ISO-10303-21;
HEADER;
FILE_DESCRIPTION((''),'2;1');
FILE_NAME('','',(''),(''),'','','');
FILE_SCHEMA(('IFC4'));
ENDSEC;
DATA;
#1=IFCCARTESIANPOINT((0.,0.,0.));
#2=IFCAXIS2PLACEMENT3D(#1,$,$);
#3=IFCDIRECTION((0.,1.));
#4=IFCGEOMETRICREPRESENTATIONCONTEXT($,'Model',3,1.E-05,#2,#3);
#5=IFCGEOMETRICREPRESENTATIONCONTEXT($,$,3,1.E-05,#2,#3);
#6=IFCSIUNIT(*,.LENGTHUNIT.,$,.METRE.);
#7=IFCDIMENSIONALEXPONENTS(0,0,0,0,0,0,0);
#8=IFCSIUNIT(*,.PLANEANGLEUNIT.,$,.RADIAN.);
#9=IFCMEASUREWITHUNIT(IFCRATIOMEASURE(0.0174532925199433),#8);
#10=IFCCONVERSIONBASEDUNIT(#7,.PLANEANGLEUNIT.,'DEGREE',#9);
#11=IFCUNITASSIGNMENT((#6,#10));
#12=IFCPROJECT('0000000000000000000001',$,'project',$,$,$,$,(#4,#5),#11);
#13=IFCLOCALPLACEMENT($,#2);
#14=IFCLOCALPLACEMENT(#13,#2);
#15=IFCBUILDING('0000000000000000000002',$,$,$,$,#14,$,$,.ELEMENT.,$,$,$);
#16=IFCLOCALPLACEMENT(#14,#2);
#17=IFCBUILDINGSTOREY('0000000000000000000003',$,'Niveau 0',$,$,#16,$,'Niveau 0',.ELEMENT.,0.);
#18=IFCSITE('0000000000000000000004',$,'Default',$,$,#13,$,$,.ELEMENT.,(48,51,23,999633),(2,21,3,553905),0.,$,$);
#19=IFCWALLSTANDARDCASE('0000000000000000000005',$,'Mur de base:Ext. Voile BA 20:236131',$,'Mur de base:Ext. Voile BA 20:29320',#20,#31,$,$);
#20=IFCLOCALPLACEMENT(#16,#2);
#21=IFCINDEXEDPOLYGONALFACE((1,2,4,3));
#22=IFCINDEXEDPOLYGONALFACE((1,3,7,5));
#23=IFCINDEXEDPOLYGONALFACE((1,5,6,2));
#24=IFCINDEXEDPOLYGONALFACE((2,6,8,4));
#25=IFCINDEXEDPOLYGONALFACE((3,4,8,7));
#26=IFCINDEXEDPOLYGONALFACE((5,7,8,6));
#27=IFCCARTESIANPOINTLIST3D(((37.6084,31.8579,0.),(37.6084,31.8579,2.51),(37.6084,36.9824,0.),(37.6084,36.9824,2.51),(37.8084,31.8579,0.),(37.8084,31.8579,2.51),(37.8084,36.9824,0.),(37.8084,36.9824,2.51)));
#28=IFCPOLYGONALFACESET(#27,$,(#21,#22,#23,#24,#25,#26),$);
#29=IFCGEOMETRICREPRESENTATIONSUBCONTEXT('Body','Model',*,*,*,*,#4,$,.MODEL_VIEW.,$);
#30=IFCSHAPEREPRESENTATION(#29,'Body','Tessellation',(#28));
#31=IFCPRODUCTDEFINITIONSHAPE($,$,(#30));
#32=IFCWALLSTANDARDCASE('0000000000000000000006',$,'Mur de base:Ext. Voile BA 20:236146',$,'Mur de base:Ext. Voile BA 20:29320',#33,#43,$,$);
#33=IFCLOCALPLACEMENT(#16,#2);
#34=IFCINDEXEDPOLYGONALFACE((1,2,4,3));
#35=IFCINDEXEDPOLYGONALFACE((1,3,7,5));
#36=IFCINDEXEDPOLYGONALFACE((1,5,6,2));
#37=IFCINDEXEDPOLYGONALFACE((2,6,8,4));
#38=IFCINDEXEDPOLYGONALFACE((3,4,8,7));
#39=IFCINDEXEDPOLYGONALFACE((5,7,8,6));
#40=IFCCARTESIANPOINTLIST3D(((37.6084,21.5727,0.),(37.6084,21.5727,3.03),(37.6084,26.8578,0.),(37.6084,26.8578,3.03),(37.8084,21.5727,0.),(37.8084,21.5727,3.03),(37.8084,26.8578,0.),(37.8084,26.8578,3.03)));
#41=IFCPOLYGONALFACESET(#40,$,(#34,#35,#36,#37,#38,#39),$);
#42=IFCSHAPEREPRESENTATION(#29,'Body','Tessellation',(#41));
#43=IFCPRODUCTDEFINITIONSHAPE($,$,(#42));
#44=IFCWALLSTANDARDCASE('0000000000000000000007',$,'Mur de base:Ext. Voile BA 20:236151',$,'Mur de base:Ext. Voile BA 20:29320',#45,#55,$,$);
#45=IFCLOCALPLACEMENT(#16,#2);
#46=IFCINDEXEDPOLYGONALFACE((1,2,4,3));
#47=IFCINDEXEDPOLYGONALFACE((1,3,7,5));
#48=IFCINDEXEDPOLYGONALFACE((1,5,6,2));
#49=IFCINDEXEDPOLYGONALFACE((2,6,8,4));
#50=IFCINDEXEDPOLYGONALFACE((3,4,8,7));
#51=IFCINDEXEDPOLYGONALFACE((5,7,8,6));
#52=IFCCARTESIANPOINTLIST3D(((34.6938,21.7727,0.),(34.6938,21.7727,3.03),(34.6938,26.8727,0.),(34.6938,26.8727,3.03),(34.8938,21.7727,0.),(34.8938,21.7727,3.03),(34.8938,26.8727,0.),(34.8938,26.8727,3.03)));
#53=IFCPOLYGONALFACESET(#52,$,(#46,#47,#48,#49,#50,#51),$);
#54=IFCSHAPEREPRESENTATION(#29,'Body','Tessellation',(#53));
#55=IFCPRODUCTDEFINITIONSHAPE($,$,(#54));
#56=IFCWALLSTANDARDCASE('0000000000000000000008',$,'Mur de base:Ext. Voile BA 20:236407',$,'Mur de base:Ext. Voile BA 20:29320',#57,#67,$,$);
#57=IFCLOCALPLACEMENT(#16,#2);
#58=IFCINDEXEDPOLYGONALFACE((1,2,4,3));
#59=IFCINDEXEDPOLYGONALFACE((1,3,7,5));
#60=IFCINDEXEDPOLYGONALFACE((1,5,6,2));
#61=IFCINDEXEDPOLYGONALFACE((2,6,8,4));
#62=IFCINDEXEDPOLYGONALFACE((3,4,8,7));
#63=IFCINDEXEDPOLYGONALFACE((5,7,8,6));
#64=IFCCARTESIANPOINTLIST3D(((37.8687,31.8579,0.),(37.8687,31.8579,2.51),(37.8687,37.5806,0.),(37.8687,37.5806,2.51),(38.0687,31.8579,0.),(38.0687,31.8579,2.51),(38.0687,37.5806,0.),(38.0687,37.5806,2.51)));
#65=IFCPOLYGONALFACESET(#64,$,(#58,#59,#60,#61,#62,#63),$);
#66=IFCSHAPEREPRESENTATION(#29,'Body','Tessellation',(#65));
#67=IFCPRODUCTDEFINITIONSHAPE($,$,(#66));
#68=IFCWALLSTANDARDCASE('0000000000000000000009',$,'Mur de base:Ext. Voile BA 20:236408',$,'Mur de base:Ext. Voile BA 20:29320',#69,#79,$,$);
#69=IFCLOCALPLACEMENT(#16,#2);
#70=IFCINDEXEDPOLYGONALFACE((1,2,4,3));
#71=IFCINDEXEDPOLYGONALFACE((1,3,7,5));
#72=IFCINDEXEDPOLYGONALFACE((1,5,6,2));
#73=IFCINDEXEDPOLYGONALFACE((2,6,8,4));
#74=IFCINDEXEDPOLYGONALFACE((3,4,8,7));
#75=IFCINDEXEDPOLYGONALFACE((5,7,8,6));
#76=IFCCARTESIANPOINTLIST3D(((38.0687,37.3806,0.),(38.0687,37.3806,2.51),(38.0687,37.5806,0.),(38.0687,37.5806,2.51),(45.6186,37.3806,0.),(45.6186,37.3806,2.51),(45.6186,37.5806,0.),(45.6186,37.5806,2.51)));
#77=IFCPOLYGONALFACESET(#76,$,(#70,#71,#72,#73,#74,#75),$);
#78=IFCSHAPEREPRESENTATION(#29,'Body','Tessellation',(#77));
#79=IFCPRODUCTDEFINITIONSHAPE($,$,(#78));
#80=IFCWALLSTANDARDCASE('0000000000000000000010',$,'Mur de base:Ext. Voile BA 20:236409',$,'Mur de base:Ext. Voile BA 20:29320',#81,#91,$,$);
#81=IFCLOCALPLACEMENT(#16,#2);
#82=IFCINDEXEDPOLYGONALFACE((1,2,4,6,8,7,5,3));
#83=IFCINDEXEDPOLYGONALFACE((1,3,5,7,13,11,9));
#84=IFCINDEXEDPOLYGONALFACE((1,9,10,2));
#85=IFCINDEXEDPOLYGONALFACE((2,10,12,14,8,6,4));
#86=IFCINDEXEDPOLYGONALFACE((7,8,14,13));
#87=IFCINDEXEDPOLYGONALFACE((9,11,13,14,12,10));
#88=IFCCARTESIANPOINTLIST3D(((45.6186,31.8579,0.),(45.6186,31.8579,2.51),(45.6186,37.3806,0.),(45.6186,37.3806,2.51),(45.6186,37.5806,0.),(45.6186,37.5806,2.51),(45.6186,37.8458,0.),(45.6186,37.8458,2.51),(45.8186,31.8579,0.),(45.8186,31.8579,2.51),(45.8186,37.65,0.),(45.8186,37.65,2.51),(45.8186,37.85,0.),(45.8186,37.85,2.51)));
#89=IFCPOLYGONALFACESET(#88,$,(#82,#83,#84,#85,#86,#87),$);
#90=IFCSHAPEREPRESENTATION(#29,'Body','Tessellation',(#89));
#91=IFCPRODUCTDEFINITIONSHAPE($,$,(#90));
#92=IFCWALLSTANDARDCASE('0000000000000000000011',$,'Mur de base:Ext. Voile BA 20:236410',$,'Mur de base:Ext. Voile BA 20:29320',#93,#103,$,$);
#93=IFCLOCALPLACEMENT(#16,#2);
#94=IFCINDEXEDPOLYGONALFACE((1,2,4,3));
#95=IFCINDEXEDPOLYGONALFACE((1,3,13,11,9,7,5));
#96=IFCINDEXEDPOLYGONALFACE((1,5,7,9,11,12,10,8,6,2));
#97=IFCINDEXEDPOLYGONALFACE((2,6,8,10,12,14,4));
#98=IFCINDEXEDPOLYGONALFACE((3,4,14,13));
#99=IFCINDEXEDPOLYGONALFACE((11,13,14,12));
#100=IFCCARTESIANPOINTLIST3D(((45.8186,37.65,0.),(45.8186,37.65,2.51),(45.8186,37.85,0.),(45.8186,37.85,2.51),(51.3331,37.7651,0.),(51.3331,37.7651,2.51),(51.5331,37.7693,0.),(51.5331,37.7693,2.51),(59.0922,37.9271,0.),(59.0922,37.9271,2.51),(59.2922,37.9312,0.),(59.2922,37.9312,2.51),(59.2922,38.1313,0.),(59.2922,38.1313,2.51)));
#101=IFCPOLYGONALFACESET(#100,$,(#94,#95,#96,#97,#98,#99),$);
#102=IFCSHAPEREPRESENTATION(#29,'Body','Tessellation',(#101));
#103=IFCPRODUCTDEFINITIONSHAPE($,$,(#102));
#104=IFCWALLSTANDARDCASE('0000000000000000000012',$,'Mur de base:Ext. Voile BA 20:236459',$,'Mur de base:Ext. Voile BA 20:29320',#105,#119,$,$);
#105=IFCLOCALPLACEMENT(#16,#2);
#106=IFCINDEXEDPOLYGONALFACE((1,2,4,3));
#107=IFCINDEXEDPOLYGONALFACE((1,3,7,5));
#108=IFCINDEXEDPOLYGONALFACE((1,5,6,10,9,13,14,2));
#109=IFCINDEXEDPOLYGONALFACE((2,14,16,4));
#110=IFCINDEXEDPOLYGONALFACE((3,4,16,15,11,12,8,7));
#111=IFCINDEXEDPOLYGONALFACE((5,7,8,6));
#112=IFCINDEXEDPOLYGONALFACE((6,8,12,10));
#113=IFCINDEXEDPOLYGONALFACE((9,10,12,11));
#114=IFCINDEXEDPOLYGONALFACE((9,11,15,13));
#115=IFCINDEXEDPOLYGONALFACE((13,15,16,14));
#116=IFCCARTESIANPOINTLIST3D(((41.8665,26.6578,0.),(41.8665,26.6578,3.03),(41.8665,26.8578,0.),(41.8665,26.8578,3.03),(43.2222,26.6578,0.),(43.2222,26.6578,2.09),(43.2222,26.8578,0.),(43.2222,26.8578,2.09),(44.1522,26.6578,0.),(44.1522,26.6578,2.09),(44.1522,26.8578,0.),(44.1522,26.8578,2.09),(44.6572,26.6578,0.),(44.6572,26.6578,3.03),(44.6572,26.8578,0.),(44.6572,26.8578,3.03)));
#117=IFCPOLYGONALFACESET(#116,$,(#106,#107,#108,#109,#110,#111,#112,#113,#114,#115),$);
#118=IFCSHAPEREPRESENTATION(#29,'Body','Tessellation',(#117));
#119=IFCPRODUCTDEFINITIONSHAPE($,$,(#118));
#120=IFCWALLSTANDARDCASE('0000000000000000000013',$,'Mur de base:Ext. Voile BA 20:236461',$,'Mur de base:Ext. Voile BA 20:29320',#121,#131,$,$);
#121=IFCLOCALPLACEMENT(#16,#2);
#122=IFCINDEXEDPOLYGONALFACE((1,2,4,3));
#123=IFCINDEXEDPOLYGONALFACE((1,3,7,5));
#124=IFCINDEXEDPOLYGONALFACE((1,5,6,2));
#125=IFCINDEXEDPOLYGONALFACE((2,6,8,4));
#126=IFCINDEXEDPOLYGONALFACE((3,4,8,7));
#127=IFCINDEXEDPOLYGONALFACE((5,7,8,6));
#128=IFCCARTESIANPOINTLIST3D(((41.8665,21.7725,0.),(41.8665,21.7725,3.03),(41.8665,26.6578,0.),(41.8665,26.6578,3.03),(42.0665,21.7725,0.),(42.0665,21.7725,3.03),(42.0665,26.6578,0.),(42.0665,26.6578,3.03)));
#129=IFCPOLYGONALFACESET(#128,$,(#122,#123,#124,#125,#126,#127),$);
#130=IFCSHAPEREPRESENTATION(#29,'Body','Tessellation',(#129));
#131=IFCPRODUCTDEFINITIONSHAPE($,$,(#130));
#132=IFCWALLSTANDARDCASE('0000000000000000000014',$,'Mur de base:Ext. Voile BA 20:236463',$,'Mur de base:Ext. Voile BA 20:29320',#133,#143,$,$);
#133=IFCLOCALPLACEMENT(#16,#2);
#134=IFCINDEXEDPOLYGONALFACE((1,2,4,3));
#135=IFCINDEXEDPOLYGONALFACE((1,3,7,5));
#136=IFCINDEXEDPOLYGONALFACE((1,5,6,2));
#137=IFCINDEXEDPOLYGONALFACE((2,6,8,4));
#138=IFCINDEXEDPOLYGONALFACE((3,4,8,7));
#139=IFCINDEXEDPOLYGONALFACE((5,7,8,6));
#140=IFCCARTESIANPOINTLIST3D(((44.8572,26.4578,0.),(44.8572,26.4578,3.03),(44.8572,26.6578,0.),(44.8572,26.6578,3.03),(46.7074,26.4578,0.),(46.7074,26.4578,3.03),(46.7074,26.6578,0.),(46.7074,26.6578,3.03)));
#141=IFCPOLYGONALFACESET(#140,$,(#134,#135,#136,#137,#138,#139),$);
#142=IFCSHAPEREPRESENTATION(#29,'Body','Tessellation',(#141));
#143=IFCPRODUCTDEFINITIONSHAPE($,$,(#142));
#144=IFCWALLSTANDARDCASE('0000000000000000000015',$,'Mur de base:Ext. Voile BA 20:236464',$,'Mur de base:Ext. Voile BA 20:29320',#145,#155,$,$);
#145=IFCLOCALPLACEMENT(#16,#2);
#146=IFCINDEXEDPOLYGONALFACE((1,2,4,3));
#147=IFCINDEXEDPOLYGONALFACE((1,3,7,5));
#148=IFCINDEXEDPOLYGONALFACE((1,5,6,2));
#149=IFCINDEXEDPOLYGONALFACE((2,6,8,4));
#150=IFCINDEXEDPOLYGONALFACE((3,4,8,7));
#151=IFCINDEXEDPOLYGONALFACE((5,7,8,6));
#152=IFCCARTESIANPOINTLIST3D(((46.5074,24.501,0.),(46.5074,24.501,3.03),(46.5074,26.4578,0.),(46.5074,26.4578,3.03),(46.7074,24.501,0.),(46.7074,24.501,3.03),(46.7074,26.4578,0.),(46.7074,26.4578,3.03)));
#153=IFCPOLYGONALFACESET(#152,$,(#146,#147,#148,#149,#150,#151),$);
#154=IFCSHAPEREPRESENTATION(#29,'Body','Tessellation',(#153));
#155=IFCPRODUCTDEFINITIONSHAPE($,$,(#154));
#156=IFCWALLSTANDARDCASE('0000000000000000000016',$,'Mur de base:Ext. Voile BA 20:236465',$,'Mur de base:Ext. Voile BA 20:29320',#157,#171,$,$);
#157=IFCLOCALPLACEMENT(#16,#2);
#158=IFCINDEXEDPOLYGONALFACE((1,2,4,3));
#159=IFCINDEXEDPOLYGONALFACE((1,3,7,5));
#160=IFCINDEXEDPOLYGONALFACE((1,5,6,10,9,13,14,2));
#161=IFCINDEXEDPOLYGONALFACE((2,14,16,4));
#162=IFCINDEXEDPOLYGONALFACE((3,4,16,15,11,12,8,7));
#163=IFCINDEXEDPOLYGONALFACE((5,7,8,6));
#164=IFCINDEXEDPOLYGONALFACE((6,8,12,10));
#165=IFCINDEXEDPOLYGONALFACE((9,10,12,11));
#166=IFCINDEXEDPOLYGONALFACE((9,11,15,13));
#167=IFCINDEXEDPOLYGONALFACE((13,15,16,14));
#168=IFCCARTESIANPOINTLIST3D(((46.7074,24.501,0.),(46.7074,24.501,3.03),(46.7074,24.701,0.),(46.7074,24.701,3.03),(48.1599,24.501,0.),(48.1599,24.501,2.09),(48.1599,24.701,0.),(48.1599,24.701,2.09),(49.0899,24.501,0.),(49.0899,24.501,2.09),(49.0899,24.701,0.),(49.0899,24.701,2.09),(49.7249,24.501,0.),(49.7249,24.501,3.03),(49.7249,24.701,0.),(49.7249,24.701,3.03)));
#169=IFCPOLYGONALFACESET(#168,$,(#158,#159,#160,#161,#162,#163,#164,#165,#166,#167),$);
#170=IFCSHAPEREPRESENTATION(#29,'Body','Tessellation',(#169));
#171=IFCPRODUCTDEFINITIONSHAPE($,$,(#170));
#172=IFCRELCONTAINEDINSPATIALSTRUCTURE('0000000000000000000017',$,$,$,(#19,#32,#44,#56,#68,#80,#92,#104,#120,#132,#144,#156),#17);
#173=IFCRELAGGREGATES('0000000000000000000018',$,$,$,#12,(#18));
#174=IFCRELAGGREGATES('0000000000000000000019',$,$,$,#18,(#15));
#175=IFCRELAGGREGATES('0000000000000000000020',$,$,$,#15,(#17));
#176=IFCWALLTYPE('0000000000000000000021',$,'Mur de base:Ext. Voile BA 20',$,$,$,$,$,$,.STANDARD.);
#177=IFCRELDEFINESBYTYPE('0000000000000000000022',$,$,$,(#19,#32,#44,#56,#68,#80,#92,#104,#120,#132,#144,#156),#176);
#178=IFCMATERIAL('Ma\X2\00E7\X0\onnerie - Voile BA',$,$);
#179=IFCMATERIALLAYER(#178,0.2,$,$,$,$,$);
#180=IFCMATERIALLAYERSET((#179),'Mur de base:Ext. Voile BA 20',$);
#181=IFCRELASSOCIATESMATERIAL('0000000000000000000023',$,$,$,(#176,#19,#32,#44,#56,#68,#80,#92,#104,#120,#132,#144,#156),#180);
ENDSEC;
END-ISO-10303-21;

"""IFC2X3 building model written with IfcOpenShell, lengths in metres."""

from ifc_helpers import new_model, entity, si_unit, converted_unit, direction, frame, frame_2d, origin, origin_2d_with_axis, place, context, subcontext, project, spatial, polyline, rectangle, outline, extrude, material, layer, layer_set, layer_usage, type_object, element, save


model = new_model("IFC2X3")

# Units and contexts
model_context = context("Model", 3, precision=1e-05, world=origin(), true_north=direction((0.0, 1.0)))
context_of_model = context(None, 3, precision=1e-05, world=origin(), true_north=direction((0.0, 1.0)))
body_context = subcontext(model_context, "Body", "Model", "MODEL_VIEW")
ifc_project = project(units=[si_unit("LENGTHUNIT", "METRE"), converted_unit("PLANEANGLEUNIT", "DEGREE", entity("IfcRatioMeasure", 0.0174532925199433), si_unit("PLANEANGLEUNIT", "RADIAN"), dimensions=[0, 0, 0, 0, 0, 0, 0])], contexts=[model_context, context_of_model])

# Site, building, storey
site_placement = place(None, origin())
site = spatial("IfcSite", under=ifc_project, at=site_placement, Name="Default", CompositionType="ELEMENT", RefLatitude=(48, 51, 23, 999633), RefLongitude=(2, 21, 3, 553905), RefElevation=0.0)
building_placement = place(site_placement, origin())
building = spatial("IfcBuilding", under=site, at=building_placement, CompositionType="ELEMENT")
storey_placement = place(building_placement, origin())
storey = spatial("IfcBuildingStorey", under=building, at=storey_placement, Name="Niveau 0", LongName="Niveau 0", CompositionType="ELEMENT", Elevation=0.0)

# Wall
ifc_material = material(Name="Maçonnerie - Voile BA")
ifc_layer_1 = layer(ifc_material, 0.2)
ifc_layer_set_1 = layer_set([ifc_layer_1], Name="Mur de base:Ext. Voile BA 20")
ifc_layer_usage_1 = layer_usage(ifc_layer_set_1, "AXIS2", "NEGATIVE", 0.1)
wall_type_1 = type_object("IfcWallType", Name="Mur de base:Ext. Voile BA 20", PredefinedType="STANDARD", material=ifc_layer_set_1)
wall_1_placement = place(storey_placement, frame((37.7084, 36.9824, 0.0), z_axis=(0.0, 0.0, 1.0), x_axis=(0.0, -1.0, 0.0)))
element("IfcWallStandardCase", 1, at=wall_1_placement, inside=storey, type_object=wall_type_1, material=ifc_layer_usage_1, Name="Mur de base:Ext. Voile BA 20:236131", ObjectType="Mur de base:Ext. Voile BA 20:29320", context=body_context, shape_type="SweptSolid", body=[
    extrude(rectangle(XDim=5.1245, YDim=0.2, at=frame_2d((2.5623, 0.0), x_axis=(-1.0, 0.0))), origin(), (0.0, 0.0, 1.0), 2.51),
])

# Walls
ifc_layer_usage_2 = layer_usage(ifc_layer_set_1, "AXIS2", "NEGATIVE", 0.1)
wall_2_placement = place(storey_placement, frame((37.7084, 26.8578, 0.0), z_axis=(0.0, 0.0, 1.0), x_axis=(0.0, -1.0, 0.0)))
element("IfcWallStandardCase", 2, at=wall_2_placement, inside=storey, type_object=wall_type_1, material=ifc_layer_usage_2, Name="Mur de base:Ext. Voile BA 20:236146", ObjectType="Mur de base:Ext. Voile BA 20:29320", context=body_context, shape_type="SweptSolid", body=[
    extrude(rectangle(XDim=5.2851, YDim=0.2, at=frame_2d((2.6425, 0.0), x_axis=(-1.0, 0.0))), origin(), (0.0, 0.0, 1.0), 3.03),
])
ifc_layer_usage_3 = layer_usage(ifc_layer_set_1, "AXIS2", "NEGATIVE", 0.1)
wall_3_placement = place(storey_placement, frame((34.7938, 21.7727, 0.0), z_axis=(0.0, 0.0, 1.0), x_axis=(0.0, 1.0, 0.0)))
element("IfcWallStandardCase", 3, at=wall_3_placement, inside=storey, type_object=wall_type_1, material=ifc_layer_usage_3, Name="Mur de base:Ext. Voile BA 20:236151", ObjectType="Mur de base:Ext. Voile BA 20:29320", context=body_context, shape_type="SweptSolid", body=[
    extrude(rectangle(XDim=5.1, YDim=0.2, at=frame_2d((2.55, 0.0), x_axis=(-1.0, 0.0))), origin(), (0.0, 0.0, 1.0), 3.03),
])
ifc_layer_usage_4 = layer_usage(ifc_layer_set_1, "AXIS2", "NEGATIVE", 0.1)
wall_4_placement = place(storey_placement, frame((37.9687, 31.8579, 0.0), z_axis=(0.0, 0.0, 1.0), x_axis=(0.0, 1.0, 0.0)))
element("IfcWallStandardCase", 4, at=wall_4_placement, inside=storey, type_object=wall_type_1, material=ifc_layer_usage_4, Name="Mur de base:Ext. Voile BA 20:236407", ObjectType="Mur de base:Ext. Voile BA 20:29320", context=body_context, shape_type="SweptSolid", body=[
    extrude(rectangle(XDim=5.7227, YDim=0.2, at=frame_2d((2.8614, 0.0), x_axis=(-1.0, 0.0))), origin(), (0.0, 0.0, 1.0), 2.51),
])
ifc_layer_usage_5 = layer_usage(ifc_layer_set_1, "AXIS2", "NEGATIVE", 0.1)
wall_5_placement = place(storey_placement, frame((38.0687, 37.4806, 0.0)))
element("IfcWallStandardCase", 5, at=wall_5_placement, inside=storey, type_object=wall_type_1, material=ifc_layer_usage_5, Name="Mur de base:Ext. Voile BA 20:236408", ObjectType="Mur de base:Ext. Voile BA 20:29320", context=body_context, shape_type="SweptSolid", body=[
    extrude(rectangle(XDim=7.5498, YDim=0.2, at=frame_2d((3.7749, 0.0), x_axis=(-1.0, 0.0))), origin(), (0.0, 0.0, 1.0), 2.51),
])
ifc_layer_usage_6 = layer_usage(ifc_layer_set_1, "AXIS2", "NEGATIVE", 0.1)
wall_6_placement = place(storey_placement, frame((45.7186, 31.8579, 0.0), z_axis=(0.0, 0.0, 1.0), x_axis=(0.0, 1.0, 0.0)))
element("IfcWallStandardCase", 6, at=wall_6_placement, inside=storey, type_object=wall_type_1, material=ifc_layer_usage_6, Name="Mur de base:Ext. Voile BA 20:236409", ObjectType="Mur de base:Ext. Voile BA 20:29320", context=body_context, shape_type="SweptSolid", body=[
    extrude(outline(polyline([(5.9921, -0.1), (5.9879, 0.1), (5.7227, 0.1), (5.5227, 0.1), (0.0, 0.1), (0.0, -0.1), (5.7921, -0.1), (5.9921, -0.1)])), origin(), (0.0, 0.0, 1.0), 2.51),
])
ifc_layer_usage_7 = layer_usage(ifc_layer_set_1, "AXIS2", "NEGATIVE", 0.1)
wall_7_placement = place(storey_placement, frame((45.8165, 37.7499, 0.0), z_axis=(0.0, 0.0, 1.0), x_axis=(0.999782, 0.020871, 0.0)))
element("IfcWallStandardCase", 7, at=wall_7_placement, inside=storey, type_object=wall_type_1, material=ifc_layer_usage_7, Name="Mur de base:Ext. Voile BA 20:236410", ObjectType="Mur de base:Ext. Voile BA 20:29320", context=body_context, shape_type="SweptSolid", body=[
    extrude(outline(polyline([(13.4766, -0.1), (13.4808, 0.1), (0.0042, 0.1), (0.0, -0.1), (5.5157, -0.1), (5.7157, -0.1), (13.2765, -0.1), (13.4766, -0.1)])), origin(), (0.0, 0.0, 1.0), 2.51),
])

# Wall, opening
ifc_layer_usage_8 = layer_usage(ifc_layer_set_1, "AXIS2", "NEGATIVE", 0.1)
wall_8_placement = place(storey_placement, frame((44.6572, 26.7578, 0.0), z_axis=(0.0, 0.0, 1.0), x_axis=(-1.0, 0.0, 0.0)))
wall_8 = element("IfcWallStandardCase", 8, at=wall_8_placement, inside=storey, type_object=wall_type_1, material=ifc_layer_usage_8, Name="Mur de base:Ext. Voile BA 20:236459", ObjectType="Mur de base:Ext. Voile BA 20:29320", context=body_context, shape_type="SweptSolid", body=[
    extrude(rectangle(XDim=2.7907, YDim=0.2, at=frame_2d((1.3954, 0.0), x_axis=(-1.0, 0.0))), origin(), (0.0, 0.0, 1.0), 3.03),
])
opening_1_placement = place(wall_8_placement, origin())
element("IfcOpeningElement", 9, at=opening_1_placement, cuts=wall_8, ObjectType="Opening", context=body_context, shape_type="SweptSolid", body=[
    extrude(rectangle(XDim=2.09, YDim=0.93, at=origin_2d_with_axis()), frame((0.97, -0.1, 1.045), z_axis=(0.0, 1.0, 0.0), x_axis=(0.0, 0.0, -1.0)), (0.0, 0.0, 1.0), 0.2),
])

# Walls
ifc_layer_usage_9 = layer_usage(ifc_layer_set_1, "AXIS2", "NEGATIVE", 0.1)
wall_9_placement = place(storey_placement, frame((41.9665, 26.6578, 0.0), z_axis=(0.0, 0.0, 1.0), x_axis=(0.0, -1.0, 0.0)))
element("IfcWallStandardCase", 10, at=wall_9_placement, inside=storey, type_object=wall_type_1, material=ifc_layer_usage_9, Name="Mur de base:Ext. Voile BA 20:236461", ObjectType="Mur de base:Ext. Voile BA 20:29320", context=body_context, shape_type="SweptSolid", body=[
    extrude(rectangle(XDim=4.8853, YDim=0.2, at=frame_2d((2.4426, 0.0), x_axis=(-1.0, 0.0))), origin(), (0.0, 0.0, 1.0), 3.03),
])
ifc_layer_usage_10 = layer_usage(ifc_layer_set_1, "AXIS2", "NEGATIVE", 0.1)
wall_10_placement = place(storey_placement, frame((44.8572, 26.5578, 0.0)))
element("IfcWallStandardCase", 11, at=wall_10_placement, inside=storey, type_object=wall_type_1, material=ifc_layer_usage_10, Name="Mur de base:Ext. Voile BA 20:236463", ObjectType="Mur de base:Ext. Voile BA 20:29320", context=body_context, shape_type="SweptSolid", body=[
    extrude(rectangle(XDim=1.8501, YDim=0.2, at=frame_2d((0.9251, 0.0), x_axis=(-1.0, 0.0))), origin(), (0.0, 0.0, 1.0), 3.03),
])
ifc_layer_usage_11 = layer_usage(ifc_layer_set_1, "AXIS2", "NEGATIVE", 0.1)
wall_11_placement = place(storey_placement, frame((46.6074, 26.4578, 0.0), z_axis=(0.0, 0.0, 1.0), x_axis=(0.0, -1.0, 0.0)))
element("IfcWallStandardCase", 12, at=wall_11_placement, inside=storey, type_object=wall_type_1, material=ifc_layer_usage_11, Name="Mur de base:Ext. Voile BA 20:236464", ObjectType="Mur de base:Ext. Voile BA 20:29320", context=body_context, shape_type="SweptSolid", body=[
    extrude(rectangle(XDim=1.9568, YDim=0.2, at=frame_2d((0.9784, 0.0), x_axis=(-1.0, 0.0))), origin(), (0.0, 0.0, 1.0), 3.03),
])

# Wall, opening
ifc_layer_usage_12 = layer_usage(ifc_layer_set_1, "AXIS2", "NEGATIVE", 0.1)
wall_12_placement = place(storey_placement, frame((46.7074, 24.601, 0.0)))
wall_12 = element("IfcWallStandardCase", 13, at=wall_12_placement, inside=storey, type_object=wall_type_1, material=ifc_layer_usage_12, Name="Mur de base:Ext. Voile BA 20:236465", ObjectType="Mur de base:Ext. Voile BA 20:29320", context=body_context, shape_type="SweptSolid", body=[
    extrude(rectangle(XDim=3.0175, YDim=0.2, at=frame_2d((1.5088, 0.0), x_axis=(-1.0, 0.0))), origin(), (0.0, 0.0, 1.0), 3.03),
])
opening_2_placement = place(wall_12_placement, origin())
element("IfcOpeningElement", 14, at=opening_2_placement, cuts=wall_12, ObjectType="Opening", context=body_context, shape_type="SweptSolid", body=[
    extrude(rectangle(XDim=2.09, YDim=0.93, at=origin_2d_with_axis()), frame((1.9175, -0.1, 1.045), z_axis=(0.0, 1.0, 0.0), x_axis=(0.0, 0.0, -1.0)), (0.0, 0.0, 1.0), 0.2),
])

save(model, "model.ifc")
